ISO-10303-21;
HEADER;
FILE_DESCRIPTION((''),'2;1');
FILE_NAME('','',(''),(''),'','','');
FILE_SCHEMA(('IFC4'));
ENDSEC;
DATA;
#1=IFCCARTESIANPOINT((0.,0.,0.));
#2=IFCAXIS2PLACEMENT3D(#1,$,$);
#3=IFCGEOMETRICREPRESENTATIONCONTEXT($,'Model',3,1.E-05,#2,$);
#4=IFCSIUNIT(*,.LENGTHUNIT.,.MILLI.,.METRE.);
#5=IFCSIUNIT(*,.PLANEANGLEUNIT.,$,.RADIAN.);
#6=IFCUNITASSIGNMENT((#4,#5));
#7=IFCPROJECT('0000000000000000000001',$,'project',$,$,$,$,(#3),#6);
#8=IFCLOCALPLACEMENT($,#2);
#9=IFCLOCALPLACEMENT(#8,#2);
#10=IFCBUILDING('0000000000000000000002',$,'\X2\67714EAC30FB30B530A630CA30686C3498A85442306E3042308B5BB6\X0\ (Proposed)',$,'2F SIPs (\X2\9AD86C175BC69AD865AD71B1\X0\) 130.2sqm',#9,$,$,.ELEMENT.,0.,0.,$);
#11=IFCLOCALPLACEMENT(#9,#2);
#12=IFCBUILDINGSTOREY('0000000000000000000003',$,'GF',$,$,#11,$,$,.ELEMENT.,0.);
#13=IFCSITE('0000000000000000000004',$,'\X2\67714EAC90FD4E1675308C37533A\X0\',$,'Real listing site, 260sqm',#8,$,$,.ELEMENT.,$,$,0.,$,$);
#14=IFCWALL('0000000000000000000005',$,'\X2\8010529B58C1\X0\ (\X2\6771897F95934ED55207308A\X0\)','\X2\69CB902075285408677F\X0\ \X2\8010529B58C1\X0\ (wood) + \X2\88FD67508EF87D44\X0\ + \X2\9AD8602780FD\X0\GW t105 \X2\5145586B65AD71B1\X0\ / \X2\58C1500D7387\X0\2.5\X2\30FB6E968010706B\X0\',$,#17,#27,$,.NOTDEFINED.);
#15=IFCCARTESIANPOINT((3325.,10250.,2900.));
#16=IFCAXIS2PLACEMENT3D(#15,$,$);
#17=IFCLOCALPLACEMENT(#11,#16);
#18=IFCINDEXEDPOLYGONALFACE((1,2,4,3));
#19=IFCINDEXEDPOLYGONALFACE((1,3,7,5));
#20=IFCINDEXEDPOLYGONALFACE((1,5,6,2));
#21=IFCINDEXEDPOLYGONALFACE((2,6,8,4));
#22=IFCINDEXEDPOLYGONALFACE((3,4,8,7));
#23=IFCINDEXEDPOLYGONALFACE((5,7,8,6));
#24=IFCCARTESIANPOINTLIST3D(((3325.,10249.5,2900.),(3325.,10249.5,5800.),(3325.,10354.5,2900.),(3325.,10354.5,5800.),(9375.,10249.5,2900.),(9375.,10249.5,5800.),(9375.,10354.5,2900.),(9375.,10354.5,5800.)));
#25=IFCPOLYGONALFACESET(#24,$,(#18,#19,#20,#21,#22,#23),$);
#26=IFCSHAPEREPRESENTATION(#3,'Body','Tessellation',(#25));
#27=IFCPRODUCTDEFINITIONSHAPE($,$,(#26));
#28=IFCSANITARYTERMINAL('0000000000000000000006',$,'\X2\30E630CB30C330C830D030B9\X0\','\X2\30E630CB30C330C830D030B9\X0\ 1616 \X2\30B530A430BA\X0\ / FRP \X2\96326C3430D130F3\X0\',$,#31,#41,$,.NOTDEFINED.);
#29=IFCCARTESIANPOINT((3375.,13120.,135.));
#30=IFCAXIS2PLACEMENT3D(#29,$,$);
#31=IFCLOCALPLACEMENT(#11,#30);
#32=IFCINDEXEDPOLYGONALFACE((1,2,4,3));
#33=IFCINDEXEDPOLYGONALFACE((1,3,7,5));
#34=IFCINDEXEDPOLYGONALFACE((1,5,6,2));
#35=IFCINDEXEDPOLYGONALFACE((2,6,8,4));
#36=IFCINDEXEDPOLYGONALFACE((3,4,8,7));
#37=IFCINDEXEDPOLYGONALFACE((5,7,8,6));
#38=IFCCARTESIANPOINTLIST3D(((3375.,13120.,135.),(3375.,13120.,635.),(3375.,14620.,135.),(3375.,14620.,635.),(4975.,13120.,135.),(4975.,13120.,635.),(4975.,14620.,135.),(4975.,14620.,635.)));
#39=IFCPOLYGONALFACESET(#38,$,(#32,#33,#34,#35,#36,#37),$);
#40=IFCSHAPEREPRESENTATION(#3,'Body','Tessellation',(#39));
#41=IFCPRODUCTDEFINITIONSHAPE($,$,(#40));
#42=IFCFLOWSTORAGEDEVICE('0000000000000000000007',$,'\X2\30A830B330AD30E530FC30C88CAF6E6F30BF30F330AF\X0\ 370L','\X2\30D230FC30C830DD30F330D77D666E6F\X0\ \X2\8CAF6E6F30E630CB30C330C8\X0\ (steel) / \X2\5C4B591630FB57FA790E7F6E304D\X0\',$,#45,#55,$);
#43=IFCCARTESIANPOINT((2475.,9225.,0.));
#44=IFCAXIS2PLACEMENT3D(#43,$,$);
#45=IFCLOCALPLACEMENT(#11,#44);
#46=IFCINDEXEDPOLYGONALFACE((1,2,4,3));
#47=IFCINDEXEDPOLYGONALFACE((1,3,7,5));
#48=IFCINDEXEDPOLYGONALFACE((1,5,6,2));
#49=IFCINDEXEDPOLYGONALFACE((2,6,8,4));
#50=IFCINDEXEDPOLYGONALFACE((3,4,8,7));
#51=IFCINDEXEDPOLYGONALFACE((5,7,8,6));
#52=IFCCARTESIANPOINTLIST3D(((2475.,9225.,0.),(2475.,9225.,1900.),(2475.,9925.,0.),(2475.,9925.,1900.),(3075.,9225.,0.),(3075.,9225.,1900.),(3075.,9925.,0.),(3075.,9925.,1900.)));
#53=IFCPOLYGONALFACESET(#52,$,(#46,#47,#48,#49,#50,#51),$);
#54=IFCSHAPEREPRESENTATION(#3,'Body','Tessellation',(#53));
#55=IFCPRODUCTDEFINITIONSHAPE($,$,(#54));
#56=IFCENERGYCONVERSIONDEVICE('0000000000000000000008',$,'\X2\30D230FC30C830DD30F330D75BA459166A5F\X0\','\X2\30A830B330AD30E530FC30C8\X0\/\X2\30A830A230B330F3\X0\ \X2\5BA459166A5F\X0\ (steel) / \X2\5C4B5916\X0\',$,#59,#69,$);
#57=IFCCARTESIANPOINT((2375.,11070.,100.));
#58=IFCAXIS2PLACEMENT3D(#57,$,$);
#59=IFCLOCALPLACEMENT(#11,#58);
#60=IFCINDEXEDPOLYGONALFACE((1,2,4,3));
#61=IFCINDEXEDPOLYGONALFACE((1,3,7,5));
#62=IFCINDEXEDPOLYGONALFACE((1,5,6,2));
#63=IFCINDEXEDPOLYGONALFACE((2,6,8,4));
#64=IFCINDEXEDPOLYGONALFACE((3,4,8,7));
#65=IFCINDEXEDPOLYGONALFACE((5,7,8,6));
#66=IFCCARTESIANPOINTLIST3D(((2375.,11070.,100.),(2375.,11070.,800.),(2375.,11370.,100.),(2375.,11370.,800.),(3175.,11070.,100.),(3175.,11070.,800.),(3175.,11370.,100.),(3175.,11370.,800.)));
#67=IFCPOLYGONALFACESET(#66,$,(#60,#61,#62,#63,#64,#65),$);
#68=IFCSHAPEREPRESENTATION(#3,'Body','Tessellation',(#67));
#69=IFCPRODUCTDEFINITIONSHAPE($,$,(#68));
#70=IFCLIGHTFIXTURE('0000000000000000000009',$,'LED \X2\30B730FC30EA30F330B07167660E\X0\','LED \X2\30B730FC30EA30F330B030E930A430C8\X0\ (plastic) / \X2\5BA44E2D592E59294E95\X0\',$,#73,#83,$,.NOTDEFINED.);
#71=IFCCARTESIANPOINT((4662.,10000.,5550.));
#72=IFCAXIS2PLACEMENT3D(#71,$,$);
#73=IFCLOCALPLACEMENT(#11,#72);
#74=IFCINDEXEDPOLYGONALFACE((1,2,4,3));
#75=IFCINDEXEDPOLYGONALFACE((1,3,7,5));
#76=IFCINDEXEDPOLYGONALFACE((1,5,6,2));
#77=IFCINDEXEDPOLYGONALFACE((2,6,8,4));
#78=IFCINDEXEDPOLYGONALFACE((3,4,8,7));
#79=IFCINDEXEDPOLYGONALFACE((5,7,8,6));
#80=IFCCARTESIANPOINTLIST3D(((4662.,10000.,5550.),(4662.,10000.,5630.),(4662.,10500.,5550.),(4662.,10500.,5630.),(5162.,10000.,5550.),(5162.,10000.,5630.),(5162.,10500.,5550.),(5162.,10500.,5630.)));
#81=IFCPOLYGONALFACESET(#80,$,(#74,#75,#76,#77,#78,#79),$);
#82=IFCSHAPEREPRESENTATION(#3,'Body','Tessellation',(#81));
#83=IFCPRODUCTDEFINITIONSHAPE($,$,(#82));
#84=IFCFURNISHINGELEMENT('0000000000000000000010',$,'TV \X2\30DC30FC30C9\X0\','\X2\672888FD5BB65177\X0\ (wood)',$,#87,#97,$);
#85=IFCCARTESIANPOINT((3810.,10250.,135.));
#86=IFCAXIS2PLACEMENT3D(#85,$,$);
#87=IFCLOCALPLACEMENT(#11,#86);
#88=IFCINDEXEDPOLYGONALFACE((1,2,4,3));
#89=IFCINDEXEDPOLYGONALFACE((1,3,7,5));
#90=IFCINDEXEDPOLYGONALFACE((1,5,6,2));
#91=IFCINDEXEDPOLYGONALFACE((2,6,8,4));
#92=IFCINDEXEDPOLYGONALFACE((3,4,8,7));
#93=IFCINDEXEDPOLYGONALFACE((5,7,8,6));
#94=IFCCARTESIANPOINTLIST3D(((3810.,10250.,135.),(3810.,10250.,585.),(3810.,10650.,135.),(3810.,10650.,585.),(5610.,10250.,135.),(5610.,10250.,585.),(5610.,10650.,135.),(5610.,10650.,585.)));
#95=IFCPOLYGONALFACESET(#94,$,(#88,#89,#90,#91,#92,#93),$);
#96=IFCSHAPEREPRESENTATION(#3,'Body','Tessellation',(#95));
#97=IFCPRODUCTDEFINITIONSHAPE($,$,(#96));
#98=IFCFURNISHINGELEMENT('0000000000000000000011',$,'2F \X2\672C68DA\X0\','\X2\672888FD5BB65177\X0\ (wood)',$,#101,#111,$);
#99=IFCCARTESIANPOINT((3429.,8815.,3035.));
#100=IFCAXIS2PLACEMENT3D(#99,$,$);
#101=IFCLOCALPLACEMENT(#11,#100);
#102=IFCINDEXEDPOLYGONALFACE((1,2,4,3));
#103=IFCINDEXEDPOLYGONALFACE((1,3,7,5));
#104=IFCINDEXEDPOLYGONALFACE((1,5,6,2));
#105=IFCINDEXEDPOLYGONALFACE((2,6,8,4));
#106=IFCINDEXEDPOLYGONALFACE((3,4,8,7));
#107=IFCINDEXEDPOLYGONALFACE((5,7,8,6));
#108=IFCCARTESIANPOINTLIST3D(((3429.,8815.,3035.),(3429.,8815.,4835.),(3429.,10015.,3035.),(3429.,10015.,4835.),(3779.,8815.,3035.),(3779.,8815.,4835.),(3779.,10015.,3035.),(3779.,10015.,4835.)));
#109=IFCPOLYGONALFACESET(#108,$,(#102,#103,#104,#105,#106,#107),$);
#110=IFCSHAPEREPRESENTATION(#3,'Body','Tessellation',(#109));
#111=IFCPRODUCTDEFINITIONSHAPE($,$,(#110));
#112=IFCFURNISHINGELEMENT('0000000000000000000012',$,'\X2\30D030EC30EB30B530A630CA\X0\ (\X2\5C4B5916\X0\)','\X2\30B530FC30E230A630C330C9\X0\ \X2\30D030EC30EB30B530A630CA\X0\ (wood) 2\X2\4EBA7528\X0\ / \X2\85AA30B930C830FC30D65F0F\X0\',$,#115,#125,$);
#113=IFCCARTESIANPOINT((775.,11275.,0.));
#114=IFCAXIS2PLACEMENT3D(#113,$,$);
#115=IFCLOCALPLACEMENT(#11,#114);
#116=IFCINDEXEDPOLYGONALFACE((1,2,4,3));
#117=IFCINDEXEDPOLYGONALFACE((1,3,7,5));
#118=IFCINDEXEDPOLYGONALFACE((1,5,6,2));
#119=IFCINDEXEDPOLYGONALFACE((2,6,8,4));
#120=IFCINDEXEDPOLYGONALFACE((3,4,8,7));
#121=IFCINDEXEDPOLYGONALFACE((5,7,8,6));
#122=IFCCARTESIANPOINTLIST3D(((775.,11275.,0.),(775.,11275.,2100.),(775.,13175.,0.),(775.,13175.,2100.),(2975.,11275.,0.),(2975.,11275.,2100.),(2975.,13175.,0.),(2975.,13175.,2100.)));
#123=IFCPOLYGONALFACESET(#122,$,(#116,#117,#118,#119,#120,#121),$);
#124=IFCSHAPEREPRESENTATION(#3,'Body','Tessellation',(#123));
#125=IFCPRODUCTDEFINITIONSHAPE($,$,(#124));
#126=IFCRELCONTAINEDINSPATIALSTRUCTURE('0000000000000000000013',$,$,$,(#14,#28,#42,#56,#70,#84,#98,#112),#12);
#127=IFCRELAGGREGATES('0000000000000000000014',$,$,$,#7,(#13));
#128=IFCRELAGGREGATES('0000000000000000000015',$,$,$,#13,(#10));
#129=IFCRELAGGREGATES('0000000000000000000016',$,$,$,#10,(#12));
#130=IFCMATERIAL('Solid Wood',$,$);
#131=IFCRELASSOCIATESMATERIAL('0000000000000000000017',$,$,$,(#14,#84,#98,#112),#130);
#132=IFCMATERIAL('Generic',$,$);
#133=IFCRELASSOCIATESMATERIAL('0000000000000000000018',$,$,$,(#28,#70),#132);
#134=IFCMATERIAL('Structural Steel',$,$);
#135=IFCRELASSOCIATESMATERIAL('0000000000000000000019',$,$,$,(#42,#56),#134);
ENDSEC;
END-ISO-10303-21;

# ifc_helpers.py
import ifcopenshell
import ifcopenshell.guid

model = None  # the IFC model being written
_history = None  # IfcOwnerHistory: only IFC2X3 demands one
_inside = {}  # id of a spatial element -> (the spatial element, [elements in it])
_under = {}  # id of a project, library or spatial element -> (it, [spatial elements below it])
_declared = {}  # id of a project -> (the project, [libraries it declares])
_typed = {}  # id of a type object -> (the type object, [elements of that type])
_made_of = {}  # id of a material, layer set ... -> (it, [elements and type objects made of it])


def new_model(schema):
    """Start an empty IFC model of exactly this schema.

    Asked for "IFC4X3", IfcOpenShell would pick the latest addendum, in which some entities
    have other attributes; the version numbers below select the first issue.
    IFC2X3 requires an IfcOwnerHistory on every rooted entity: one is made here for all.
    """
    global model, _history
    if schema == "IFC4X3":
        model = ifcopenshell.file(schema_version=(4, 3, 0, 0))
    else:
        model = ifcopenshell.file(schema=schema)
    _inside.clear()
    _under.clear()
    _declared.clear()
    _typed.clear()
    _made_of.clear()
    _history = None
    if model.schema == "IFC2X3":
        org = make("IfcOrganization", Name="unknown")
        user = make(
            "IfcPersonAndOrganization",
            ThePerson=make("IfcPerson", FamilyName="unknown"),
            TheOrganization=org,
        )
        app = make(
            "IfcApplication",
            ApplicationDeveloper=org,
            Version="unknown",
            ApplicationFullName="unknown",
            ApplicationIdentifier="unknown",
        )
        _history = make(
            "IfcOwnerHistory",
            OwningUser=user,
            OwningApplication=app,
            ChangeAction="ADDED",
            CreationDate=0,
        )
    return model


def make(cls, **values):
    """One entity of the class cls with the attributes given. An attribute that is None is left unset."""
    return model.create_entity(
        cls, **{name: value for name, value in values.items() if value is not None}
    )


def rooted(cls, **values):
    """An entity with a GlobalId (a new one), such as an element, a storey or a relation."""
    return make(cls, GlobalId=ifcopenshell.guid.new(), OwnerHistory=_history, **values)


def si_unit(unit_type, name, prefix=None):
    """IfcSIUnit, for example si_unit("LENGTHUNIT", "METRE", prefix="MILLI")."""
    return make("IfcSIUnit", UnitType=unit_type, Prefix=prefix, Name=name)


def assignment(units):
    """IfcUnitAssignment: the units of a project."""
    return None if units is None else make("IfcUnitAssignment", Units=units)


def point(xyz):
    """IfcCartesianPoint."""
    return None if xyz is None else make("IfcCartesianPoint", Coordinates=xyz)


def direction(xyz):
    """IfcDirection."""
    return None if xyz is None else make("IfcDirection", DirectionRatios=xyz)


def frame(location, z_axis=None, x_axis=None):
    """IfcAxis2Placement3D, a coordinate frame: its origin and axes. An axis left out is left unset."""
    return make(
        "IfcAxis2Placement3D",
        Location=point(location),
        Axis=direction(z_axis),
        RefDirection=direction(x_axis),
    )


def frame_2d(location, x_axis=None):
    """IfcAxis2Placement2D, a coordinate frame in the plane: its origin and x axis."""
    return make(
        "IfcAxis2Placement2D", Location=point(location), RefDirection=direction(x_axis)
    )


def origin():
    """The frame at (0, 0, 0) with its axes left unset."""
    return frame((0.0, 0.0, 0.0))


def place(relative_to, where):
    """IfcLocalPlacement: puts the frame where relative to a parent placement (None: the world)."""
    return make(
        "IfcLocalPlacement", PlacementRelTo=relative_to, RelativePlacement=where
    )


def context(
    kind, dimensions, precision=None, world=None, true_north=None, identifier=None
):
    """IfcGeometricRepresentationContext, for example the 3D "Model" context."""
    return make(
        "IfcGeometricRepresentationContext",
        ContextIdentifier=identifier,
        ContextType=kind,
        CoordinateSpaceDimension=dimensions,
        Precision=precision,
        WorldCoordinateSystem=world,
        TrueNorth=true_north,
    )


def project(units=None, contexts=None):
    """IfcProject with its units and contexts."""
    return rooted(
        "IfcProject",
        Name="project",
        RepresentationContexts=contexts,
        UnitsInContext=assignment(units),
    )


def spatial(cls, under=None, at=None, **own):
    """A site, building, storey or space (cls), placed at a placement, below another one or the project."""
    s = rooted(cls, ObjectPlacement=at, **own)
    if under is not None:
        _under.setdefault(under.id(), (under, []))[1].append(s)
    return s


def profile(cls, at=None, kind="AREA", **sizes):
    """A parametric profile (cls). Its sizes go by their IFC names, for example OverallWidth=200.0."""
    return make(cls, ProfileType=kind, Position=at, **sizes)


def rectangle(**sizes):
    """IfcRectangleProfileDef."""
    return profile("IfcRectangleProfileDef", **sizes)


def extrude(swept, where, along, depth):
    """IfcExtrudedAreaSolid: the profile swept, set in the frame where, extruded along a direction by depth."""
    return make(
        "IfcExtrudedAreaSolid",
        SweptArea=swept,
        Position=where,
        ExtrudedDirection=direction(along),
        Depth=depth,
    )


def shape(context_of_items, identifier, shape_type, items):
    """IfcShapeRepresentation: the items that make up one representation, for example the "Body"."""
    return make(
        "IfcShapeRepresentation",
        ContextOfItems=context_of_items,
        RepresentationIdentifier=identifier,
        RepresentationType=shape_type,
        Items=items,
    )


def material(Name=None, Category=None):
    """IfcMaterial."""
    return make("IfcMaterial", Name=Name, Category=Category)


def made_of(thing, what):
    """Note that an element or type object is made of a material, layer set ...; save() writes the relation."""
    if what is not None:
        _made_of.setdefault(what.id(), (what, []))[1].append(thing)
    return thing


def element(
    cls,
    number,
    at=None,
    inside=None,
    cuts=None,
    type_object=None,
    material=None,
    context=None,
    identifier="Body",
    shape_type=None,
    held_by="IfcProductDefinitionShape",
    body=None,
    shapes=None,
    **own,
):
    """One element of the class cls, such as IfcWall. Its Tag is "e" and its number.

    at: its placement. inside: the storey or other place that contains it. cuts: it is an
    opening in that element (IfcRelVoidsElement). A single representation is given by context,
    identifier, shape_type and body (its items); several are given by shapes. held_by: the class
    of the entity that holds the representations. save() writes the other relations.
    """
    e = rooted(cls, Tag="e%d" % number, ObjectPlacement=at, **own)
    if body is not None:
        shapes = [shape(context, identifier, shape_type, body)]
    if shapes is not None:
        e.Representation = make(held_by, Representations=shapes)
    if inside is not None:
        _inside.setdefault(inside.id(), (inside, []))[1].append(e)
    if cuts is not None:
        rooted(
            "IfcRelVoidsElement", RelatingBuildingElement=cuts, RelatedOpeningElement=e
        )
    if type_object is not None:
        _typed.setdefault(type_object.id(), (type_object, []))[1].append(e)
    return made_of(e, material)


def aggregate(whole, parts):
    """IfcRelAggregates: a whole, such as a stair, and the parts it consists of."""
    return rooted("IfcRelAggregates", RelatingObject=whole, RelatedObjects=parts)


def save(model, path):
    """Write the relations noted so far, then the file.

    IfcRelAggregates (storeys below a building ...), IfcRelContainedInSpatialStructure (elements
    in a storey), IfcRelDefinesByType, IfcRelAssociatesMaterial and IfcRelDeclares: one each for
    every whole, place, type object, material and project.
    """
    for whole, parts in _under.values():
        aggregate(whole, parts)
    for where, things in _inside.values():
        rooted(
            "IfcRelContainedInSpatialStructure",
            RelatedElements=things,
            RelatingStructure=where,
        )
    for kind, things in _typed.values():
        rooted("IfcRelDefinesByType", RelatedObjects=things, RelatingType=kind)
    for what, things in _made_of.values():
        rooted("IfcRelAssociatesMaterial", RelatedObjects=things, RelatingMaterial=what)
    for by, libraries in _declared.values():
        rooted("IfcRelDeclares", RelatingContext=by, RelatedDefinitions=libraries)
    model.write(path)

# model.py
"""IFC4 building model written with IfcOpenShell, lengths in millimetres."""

from ifc_helpers import new_model, si_unit, frame, frame_2d, origin, place, context, project, spatial, rectangle, extrude, material, element, save


model = new_model("IFC4")

# Units and contexts
model_context = context("Model", 3, precision=1e-05, world=origin())
ifc_project = project(units=[si_unit("LENGTHUNIT", "METRE", prefix="MILLI"), si_unit("PLANEANGLEUNIT", "RADIAN")], contexts=[model_context])

# Site, building, storey
site_placement = place(None, origin())
site = spatial("IfcSite", under=ifc_project, at=site_placement, Name="東京都世田谷区", ObjectType="Real listing site, 260sqm", CompositionType="ELEMENT", RefElevation=0.0)
building_placement = place(site_placement, origin())
building = spatial("IfcBuilding", under=site, at=building_placement, Name="東京・サウナと水風呂のある家 (Proposed)", ObjectType="2F SIPs (高気密高断熱) 130.2sqm", CompositionType="ELEMENT", ElevationOfRefHeight=0.0, ElevationOfTerrain=0.0)
storey_placement = place(building_placement, origin())
storey = spatial("IfcBuildingStorey", under=building, at=storey_placement, Name="GF", CompositionType="ELEMENT", Elevation=0.0)

# Shared definitions
ifc_material_1 = material(Name="Solid Wood")

# Wall
wall_1_placement = place(storey_placement, frame((3325.0, 10250.0, 2900.0)))
element("IfcWall", 1, at=wall_1_placement, inside=storey, material=ifc_material_1, Name="耐力壁 (東西間仕切り)", Description="構造用合板 耐力壁 (wood) + 製材軸組 + 高性能GW t105 充填断熱 / 壁倍率2.5・準耐火", PredefinedType="NOTDEFINED", context=model_context, shape_type="SweptSolid", body=[
    extrude(rectangle(XDim=6050.0, YDim=105.0, at=frame_2d((3025.0, 52.0))), frame((3325.0, 10250.0, 2900.0)), (0.0, 0.0, 1.0), 2900.0),
])

# Sanitary terminal
ifc_material_2 = material(Name="Generic")
sanitary_terminal_placement = place(storey_placement, frame((3375.0, 13120.0, 135.0)))
element("IfcSanitaryTerminal", 2, at=sanitary_terminal_placement, inside=storey, material=ifc_material_2, Name="ユニットバス", Description="ユニットバス 1616 サイズ / FRP 防水パン", PredefinedType="NOTDEFINED", context=model_context, shape_type="SweptSolid", body=[
    extrude(rectangle(XDim=1600.0, YDim=1500.0, at=frame_2d((800.0, 750.0))), frame((3375.0, 13120.0, 135.0)), (0.0, 0.0, 1.0), 500.0),
])

# Flow storage device
ifc_material_3 = material(Name="Structural Steel")
flow_storage_device_placement = place(storey_placement, frame((2475.0, 9225.0, 0.0)))
element("IfcFlowStorageDevice", 3, at=flow_storage_device_placement, inside=storey, material=ifc_material_3, Name="エコキュート貯湯タンク 370L", Description="ヒートポンプ給湯 貯湯ユニット (steel) / 屋外・基礎置き", context=model_context, shape_type="SweptSolid", body=[
    extrude(rectangle(XDim=600.0, YDim=700.0, at=frame_2d((300.0, 350.0))), frame((2475.0, 9225.0, 0.0)), (0.0, 0.0, 1.0), 1900.0),
])

# Energy conversion device
energy_conversion_device_placement = place(storey_placement, frame((2375.0, 11070.0, 100.0)))
element("IfcEnergyConversionDevice", 4, at=energy_conversion_device_placement, inside=storey, material=ifc_material_3, Name="ヒートポンプ室外機", Description="エコキュート/エアコン 室外機 (steel) / 屋外", context=model_context, shape_type="SweptSolid", body=[
    extrude(rectangle(XDim=800.0, YDim=300.0, at=frame_2d((400.0, 150.0))), frame((2375.0, 11070.0, 100.0)), (0.0, 0.0, 1.0), 700.0),
])

# Light fixture
light_fixture_placement = place(storey_placement, frame((4662.0, 10000.0, 5550.0)))
element("IfcLightFixture", 5, at=light_fixture_placement, inside=storey, material=ifc_material_2, Name="LED シーリング照明", Description="LED シーリングライト (plastic) / 室中央天井", PredefinedType="NOTDEFINED", context=model_context, shape_type="SweptSolid", body=[
    extrude(rectangle(XDim=500.0, YDim=500.0, at=frame_2d((250.0, 250.0))), frame((4662.0, 10000.0, 5550.0)), (0.0, 0.0, 1.0), 80.0),
])

# Furnishing elements
furnishing_1_placement = place(storey_placement, frame((3810.0, 10250.0, 135.0)))
element("IfcFurnishingElement", 6, at=furnishing_1_placement, inside=storey, material=ifc_material_1, Name="TV ボード", Description="木製家具 (wood)", context=model_context, shape_type="SweptSolid", body=[
    extrude(rectangle(XDim=1800.0, YDim=400.0, at=frame_2d((900.0, 200.0))), frame((3810.0, 10250.0, 135.0)), (0.0, 0.0, 1.0), 450.0),
])
furnishing_2_placement = place(storey_placement, frame((3429.0, 8815.0, 3035.0)))
element("IfcFurnishingElement", 7, at=furnishing_2_placement, inside=storey, material=ifc_material_1, Name="2F 本棚", Description="木製家具 (wood)", context=model_context, shape_type="SweptSolid", body=[
    extrude(rectangle(XDim=350.0, YDim=1200.0, at=frame_2d((175.0, 600.0))), frame((3429.0, 8815.0, 3035.0)), (0.0, 0.0, 1.0), 1800.0),
])
furnishing_3_placement = place(storey_placement, frame((775.0, 11275.0, 0.0)))
element("IfcFurnishingElement", 8, at=furnishing_3_placement, inside=storey, material=ifc_material_1, Name="バレルサウナ (屋外)", Description="サーモウッド バレルサウナ (wood) 2人用 / 薪ストーブ式", context=model_context, shape_type="SweptSolid", body=[
    extrude(rectangle(XDim=2200.0, YDim=1900.0, at=frame_2d((1100.0, 950.0))), frame((775.0, 11275.0, 0.0)), (0.0, 0.0, 1.0), 2100.0),
])

save(model, "model.ifc")
